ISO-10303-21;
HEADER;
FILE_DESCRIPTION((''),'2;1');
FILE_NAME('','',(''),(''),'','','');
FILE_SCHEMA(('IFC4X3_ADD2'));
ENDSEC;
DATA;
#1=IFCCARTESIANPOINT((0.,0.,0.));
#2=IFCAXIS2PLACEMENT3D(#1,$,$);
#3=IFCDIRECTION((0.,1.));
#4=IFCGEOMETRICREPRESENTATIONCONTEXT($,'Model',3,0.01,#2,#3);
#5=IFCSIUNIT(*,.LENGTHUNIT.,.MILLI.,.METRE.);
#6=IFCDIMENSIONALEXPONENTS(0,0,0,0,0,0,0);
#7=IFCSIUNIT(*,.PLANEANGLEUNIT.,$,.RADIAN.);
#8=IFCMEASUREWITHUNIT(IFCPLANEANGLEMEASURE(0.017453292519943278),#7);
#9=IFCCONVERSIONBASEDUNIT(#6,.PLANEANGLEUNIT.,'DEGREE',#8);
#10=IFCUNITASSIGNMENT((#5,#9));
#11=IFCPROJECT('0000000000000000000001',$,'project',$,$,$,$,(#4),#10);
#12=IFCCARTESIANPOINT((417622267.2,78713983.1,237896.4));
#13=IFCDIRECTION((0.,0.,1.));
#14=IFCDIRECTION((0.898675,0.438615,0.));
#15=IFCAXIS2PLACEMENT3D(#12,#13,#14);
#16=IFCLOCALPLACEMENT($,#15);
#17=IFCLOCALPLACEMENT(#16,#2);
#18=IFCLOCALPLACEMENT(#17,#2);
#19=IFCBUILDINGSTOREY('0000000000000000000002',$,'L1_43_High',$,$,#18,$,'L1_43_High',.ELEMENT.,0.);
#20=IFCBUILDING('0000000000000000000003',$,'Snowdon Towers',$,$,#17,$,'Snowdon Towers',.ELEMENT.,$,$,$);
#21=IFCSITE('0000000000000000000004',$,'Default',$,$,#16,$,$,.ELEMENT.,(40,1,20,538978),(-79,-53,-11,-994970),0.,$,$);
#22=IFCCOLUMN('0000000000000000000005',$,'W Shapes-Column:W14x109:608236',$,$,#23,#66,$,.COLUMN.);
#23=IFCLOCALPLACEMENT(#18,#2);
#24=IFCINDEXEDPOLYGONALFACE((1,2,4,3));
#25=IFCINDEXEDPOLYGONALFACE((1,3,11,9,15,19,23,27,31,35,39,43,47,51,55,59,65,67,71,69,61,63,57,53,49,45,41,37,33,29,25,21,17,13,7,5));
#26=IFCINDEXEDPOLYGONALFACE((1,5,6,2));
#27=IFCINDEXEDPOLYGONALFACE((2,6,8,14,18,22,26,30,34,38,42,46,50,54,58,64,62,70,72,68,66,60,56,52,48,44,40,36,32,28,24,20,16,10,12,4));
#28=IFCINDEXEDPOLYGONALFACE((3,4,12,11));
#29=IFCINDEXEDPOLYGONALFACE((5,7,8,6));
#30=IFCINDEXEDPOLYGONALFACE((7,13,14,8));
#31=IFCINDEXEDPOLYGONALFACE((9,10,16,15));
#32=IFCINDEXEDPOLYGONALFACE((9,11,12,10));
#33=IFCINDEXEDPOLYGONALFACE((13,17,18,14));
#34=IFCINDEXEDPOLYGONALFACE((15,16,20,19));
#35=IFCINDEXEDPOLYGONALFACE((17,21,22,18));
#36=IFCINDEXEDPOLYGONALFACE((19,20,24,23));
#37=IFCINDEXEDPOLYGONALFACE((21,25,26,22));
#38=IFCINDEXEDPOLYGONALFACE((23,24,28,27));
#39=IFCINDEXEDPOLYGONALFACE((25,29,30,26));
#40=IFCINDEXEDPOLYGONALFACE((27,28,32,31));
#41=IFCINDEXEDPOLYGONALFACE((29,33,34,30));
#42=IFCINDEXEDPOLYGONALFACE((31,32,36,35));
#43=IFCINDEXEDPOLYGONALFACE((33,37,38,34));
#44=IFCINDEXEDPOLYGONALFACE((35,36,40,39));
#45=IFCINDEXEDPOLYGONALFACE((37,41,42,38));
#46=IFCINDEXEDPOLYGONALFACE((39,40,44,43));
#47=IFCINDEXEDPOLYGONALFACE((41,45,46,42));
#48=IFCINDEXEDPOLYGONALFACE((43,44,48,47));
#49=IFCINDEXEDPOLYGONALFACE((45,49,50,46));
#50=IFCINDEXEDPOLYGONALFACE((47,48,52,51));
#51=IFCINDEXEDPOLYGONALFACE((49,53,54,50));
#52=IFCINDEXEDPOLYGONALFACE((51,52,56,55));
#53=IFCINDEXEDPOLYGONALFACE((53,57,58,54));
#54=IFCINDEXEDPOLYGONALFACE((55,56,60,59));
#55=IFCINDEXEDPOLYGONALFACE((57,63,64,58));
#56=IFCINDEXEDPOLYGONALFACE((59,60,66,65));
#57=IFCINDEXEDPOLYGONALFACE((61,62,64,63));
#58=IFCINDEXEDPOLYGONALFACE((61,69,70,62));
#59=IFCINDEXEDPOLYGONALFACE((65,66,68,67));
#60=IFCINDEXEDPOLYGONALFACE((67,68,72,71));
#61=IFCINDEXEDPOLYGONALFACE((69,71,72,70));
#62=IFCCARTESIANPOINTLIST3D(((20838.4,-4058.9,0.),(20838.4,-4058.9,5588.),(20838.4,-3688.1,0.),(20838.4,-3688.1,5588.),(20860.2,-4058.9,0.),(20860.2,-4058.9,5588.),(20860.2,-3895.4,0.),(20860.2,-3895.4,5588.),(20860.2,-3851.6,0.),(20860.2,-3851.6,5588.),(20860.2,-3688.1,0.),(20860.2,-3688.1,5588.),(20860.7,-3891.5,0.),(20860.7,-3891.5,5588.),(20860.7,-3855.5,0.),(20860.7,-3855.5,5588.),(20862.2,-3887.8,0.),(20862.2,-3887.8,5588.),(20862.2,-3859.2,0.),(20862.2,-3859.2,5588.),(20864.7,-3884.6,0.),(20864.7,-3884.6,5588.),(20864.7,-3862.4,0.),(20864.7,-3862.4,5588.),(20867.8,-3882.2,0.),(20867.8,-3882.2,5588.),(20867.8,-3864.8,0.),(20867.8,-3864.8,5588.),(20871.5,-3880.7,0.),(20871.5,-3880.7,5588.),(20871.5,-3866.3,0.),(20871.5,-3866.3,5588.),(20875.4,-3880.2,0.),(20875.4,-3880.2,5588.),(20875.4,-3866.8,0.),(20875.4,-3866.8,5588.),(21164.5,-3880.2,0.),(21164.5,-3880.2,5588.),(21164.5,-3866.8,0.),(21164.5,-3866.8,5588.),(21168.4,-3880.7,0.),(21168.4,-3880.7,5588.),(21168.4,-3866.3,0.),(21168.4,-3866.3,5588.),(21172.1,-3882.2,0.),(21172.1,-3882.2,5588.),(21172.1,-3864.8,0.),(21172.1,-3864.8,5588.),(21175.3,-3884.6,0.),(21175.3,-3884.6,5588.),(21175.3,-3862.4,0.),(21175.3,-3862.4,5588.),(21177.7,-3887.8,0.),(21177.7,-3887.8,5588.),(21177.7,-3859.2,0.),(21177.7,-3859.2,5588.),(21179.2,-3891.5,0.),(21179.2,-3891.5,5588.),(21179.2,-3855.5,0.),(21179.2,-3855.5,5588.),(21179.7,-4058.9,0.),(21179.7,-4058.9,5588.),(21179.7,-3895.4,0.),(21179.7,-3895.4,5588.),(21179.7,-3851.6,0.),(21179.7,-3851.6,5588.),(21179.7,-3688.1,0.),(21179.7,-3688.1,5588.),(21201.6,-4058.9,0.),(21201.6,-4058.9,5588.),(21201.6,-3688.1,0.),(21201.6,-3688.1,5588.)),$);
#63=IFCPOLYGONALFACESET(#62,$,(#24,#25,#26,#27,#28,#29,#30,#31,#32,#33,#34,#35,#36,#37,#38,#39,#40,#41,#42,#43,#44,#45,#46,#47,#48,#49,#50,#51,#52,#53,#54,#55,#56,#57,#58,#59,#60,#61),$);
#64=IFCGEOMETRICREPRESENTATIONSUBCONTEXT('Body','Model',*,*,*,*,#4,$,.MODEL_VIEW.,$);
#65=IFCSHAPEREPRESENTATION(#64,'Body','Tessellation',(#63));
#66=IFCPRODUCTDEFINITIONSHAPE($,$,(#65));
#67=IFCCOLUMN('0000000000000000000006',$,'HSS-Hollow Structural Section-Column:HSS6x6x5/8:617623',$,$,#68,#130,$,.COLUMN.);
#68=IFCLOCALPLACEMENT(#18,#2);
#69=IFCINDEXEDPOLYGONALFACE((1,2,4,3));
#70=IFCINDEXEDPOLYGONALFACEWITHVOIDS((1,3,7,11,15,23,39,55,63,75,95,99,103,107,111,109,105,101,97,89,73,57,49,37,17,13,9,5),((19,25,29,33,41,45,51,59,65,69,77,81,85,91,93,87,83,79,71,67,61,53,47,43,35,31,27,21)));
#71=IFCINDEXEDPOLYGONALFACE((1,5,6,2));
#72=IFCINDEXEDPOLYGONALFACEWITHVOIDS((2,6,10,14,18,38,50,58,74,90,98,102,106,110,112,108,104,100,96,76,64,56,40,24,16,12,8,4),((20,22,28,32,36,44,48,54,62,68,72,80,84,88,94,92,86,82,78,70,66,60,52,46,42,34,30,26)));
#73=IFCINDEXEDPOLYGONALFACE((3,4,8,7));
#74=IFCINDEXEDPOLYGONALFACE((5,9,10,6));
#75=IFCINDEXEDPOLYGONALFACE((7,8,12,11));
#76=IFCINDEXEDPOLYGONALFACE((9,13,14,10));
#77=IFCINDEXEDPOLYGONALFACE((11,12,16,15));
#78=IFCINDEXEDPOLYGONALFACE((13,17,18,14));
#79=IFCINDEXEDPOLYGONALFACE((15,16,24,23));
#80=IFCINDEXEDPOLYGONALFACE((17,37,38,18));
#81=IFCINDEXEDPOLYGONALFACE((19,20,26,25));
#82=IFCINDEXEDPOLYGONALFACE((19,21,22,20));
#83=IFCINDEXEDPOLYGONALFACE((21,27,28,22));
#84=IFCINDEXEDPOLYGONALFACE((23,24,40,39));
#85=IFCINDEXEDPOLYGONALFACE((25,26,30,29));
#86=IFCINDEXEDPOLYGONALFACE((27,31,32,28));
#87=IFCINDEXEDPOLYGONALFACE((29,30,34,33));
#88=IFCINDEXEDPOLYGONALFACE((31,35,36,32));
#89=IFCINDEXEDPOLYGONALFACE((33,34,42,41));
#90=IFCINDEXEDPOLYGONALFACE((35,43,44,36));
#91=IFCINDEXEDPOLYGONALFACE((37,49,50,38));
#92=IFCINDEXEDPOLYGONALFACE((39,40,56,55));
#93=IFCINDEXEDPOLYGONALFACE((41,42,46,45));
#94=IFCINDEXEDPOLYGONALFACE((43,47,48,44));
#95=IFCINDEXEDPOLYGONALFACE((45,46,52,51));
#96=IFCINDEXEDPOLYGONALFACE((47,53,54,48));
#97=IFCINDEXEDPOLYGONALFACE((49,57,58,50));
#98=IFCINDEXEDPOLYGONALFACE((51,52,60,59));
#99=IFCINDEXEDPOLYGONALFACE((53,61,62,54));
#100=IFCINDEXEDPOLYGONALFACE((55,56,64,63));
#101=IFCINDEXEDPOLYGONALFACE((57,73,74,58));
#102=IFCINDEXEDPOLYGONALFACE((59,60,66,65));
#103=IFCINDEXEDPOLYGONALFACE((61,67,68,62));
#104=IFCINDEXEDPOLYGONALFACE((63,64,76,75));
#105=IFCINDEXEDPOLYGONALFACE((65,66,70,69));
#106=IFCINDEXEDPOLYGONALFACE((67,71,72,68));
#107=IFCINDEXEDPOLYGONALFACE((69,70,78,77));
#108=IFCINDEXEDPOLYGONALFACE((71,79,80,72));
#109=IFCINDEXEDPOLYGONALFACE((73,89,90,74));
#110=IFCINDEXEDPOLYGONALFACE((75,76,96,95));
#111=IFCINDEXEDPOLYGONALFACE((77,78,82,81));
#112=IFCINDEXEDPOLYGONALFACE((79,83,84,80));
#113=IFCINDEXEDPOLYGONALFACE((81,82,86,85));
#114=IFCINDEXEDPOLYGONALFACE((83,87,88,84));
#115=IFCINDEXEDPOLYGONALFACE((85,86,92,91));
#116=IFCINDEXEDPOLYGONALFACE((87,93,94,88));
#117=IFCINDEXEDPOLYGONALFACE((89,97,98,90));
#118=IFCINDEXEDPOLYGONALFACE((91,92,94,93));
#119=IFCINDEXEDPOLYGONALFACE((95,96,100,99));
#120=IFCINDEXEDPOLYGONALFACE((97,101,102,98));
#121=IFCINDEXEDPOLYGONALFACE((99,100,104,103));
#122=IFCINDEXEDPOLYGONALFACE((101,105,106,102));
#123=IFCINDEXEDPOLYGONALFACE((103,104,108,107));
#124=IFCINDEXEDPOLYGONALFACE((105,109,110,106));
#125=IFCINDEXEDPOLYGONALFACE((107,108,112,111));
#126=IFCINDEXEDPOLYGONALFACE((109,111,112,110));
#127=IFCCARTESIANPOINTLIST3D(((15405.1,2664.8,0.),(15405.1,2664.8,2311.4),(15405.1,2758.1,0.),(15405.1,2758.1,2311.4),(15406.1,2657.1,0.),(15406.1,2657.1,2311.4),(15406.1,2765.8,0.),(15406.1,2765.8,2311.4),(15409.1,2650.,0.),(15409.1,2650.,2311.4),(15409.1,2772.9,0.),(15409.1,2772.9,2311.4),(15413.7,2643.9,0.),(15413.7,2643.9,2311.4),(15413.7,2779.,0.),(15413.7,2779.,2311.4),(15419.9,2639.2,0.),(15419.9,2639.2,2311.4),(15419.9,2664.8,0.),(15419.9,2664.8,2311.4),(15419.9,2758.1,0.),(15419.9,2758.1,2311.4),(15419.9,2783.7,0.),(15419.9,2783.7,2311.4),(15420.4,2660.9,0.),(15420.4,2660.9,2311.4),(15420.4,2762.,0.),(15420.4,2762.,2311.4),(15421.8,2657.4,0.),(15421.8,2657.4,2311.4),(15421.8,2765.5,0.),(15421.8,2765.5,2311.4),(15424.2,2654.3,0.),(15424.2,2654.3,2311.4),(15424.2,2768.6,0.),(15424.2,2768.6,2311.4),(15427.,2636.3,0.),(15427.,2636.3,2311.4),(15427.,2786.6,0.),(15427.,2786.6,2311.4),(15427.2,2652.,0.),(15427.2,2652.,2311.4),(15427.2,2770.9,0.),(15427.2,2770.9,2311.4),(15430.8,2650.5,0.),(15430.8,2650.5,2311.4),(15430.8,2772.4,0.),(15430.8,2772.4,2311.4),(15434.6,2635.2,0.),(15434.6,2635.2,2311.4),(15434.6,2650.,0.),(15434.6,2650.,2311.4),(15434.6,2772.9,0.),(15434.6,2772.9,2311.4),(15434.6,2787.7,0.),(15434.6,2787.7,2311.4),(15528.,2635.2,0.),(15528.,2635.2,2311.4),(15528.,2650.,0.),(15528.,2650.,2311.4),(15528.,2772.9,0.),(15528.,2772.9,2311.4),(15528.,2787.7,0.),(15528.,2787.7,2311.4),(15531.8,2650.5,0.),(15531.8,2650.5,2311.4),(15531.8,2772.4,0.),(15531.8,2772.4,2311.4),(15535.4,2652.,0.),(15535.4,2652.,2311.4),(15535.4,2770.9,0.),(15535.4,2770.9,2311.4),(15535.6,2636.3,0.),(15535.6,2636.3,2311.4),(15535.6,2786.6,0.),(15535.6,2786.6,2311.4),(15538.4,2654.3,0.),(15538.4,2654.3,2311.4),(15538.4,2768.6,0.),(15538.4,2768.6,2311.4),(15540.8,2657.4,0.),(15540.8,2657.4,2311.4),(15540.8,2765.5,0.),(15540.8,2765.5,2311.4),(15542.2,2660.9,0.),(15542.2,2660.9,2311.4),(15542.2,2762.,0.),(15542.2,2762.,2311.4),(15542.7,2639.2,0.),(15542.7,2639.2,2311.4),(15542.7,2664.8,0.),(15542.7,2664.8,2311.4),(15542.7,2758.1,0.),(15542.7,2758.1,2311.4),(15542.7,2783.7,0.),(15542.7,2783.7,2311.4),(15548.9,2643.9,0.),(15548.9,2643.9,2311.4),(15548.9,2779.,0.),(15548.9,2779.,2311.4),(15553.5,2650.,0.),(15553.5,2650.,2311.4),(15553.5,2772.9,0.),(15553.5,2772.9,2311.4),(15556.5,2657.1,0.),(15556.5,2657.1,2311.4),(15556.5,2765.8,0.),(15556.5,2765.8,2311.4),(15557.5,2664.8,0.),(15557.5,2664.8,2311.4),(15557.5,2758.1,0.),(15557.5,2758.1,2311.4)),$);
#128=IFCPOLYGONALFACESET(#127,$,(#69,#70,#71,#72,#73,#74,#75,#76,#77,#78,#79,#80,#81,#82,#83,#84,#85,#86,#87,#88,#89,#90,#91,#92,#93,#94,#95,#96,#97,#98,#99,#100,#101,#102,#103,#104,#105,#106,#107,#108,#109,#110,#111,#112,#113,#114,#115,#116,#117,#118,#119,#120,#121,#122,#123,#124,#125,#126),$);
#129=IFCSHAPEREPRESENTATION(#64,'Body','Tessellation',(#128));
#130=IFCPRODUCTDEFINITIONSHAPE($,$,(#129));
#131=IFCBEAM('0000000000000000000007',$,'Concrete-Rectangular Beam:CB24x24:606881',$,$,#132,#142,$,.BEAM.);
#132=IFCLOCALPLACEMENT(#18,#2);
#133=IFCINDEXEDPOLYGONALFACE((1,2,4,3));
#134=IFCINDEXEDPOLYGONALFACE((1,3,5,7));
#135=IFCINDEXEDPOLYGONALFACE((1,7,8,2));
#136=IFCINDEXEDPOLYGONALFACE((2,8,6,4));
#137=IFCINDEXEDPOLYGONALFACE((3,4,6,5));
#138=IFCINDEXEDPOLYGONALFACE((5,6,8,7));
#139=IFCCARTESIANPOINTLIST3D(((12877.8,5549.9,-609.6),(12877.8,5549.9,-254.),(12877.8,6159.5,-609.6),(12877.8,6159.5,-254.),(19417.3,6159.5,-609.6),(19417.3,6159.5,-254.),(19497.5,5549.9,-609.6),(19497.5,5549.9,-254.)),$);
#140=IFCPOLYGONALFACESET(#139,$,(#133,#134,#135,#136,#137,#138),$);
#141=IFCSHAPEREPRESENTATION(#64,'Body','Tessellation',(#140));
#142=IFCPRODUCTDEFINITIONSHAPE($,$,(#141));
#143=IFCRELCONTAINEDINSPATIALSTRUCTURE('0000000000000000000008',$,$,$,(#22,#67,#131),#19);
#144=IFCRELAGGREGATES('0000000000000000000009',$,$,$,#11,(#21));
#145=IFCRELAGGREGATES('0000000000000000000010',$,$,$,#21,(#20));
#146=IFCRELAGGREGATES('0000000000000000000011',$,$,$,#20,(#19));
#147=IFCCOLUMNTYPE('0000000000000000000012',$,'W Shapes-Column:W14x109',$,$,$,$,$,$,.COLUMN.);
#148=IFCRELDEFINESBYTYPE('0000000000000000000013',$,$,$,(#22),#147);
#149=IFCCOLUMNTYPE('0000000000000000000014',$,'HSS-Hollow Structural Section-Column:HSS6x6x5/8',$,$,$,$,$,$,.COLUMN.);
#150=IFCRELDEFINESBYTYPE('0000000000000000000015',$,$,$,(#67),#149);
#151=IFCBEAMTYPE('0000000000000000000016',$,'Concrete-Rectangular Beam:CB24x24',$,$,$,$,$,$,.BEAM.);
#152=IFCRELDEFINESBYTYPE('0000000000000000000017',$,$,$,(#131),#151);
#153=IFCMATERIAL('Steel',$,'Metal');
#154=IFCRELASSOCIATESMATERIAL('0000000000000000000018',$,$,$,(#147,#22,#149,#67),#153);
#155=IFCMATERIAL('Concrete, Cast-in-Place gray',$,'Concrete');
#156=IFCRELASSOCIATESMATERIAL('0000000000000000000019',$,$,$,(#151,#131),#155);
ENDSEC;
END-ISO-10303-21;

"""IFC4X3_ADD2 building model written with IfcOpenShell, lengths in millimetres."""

from ifc_helpers import new_model, entity, si_unit, converted_unit, direction, frame, frame_2d, origin, place, context, subcontext, project, spatial, polyline, circle_curve, parameter, trimmed, segment, composite_curve, rectangle, i_section, outline, extrude, clip, halfspace, source, transform, mapped, material, material_profile, profile_set, profile_usage, type_object, type_shapes, element, save


model = new_model("IFC4X3_ADD2")

# Units and contexts
model_context = context("Model", 3, precision=0.01, world=origin(), true_north=direction((0.0, 1.0)))
body_context = subcontext(model_context, "Body", "Model", "MODEL_VIEW")
ifc_project = project(units=[si_unit("LENGTHUNIT", "METRE", prefix="MILLI"), converted_unit("PLANEANGLEUNIT", "DEGREE", entity("IfcPlaneAngleMeasure", 0.017453292519943278), si_unit("PLANEANGLEUNIT", "RADIAN"), dimensions=[0, 0, 0, 0, 0, 0, 0])], contexts=[model_context])

# Site, building, storey
site_placement = place(None, frame((417622267.2, 78713983.1, 237896.4), z_axis=(0.0, 0.0, 1.0), x_axis=(0.898675, 0.438615, 0.0)))
site = spatial("IfcSite", under=ifc_project, at=site_placement, Name="Default", CompositionType="ELEMENT", RefLatitude=(40, 1, 20, 538978), RefLongitude=(-79, -53, -11, -994970), RefElevation=0.0)
building_placement = place(site_placement, origin())
building = spatial("IfcBuilding", under=site, at=building_placement, Name="Snowdon Towers", LongName="Snowdon Towers", CompositionType="ELEMENT")
storey_placement = place(building_placement, origin())
storey = spatial("IfcBuildingStorey", under=building, at=storey_placement, Name="L1_43_High", LongName="L1_43_High", CompositionType="ELEMENT", Elevation=0.0)

# Columns
ifc_material_1 = material(Name="Steel", Category="Metal")
ifc_material_profile_1 = material_profile(ifc_material_1, i_section(OverallWidth=370.8, OverallDepth=363.2, WebThickness=13.3, FlangeThickness=21.8, FilletRadius=15.2, at=frame_2d((0.0, 0.0), x_axis=(1.0, 0.0))), Name="W14x109")
ifc_profile_set_1 = profile_set([ifc_material_profile_1], Name="W14x109")
ifc_profile_usage_1 = profile_usage(ifc_profile_set_1)
column_type_1 = type_object("IfcColumnType", Name="W Shapes-Column:W14x109", PredefinedType="COLUMN", material=ifc_profile_set_1)
shared_shape_1 = source(origin(), body_context, "Body", "SweptSolid", [
    extrude(i_section(OverallWidth=370.8, OverallDepth=363.2, WebThickness=13.3, FlangeThickness=21.8, FilletRadius=15.2, at=frame_2d((0.0, 0.0), x_axis=(1.0, 0.0))), frame((0.0, 0.0, 0.0), z_axis=(0.0, 0.0, 1.0), x_axis=(-1.0, 0.0, 0.0)), (0.0, 0.0, 1.0), 5588.0),
])
type_shapes(column_type_1, [shared_shape_1])
for number, where, z_axis, x_axis, name in (
    (1, (21020.0, -3873.5, 0.0), (0.0, 0.0, 1.0), (0.0, 1.0, 0.0), "W Shapes-Column:W14x109:608236"),
):
    element("IfcColumn", number, at=place(storey_placement, frame(where, z_axis=z_axis, x_axis=x_axis)), inside=storey, type_object=column_type_1, material=ifc_profile_usage_1, Name=name, PredefinedType="COLUMN", context=body_context, shape_type="MappedRepresentation", body=[
        mapped(shared_shape_1, transform((0.0, 0.0, 0.0), scale=1.0)),
    ])
ifc_material_profile_2 = material_profile(ifc_material_1, outline(composite_curve([segment(polyline([(-46.7, -76.2), (46.7, -76.2)]), True, "CONTINUOUS"), segment(trimmed(circle_curve(frame_2d((46.7, -46.7), x_axis=(-1.0, 0.0)), 29.5), [parameter(90.0)], [parameter(180.0)], True, "PARAMETER"), True, "CONTINUOUS"), segment(polyline([(76.2, -46.7), (76.2, 46.7)]), True, "CONTINUOUS"), segment(trimmed(circle_curve(frame_2d((46.7, 46.7), x_axis=(-1.0, 0.0)), 29.5), [parameter(180.0)], [parameter(270.0)], True, "PARAMETER"), True, "CONTINUOUS"), segment(polyline([(46.7, 76.2), (-46.7, 76.2)]), True, "CONTINUOUS"), segment(trimmed(circle_curve(frame_2d((-46.7, 46.7), x_axis=(-1.0, 0.0)), 29.5), [parameter(270.0)], [parameter(360.0)], True, "PARAMETER"), True, "CONTINUOUS"), segment(polyline([(-76.2, 46.7), (-76.2, -46.7)]), True, "CONTINUOUS"), segment(trimmed(circle_curve(frame_2d((-46.7, -46.7), x_axis=(-1.0, 0.0)), 29.5), [parameter(360.0)], [parameter(90.0)], True, "PARAMETER"), True, "CONTINUOUS")], self_intersect=False), holes=[composite_curve([segment(trimmed(circle_curve(frame_2d((-46.7, -46.7), x_axis=(-1.0, 0.0)), 14.8), [parameter(0.0)], [parameter(90.0)], True, "PARAMETER"), False, "CONTINUOUS"), segment(polyline([(-61.4, -46.7), (-61.4, 46.7)]), True, "CONTINUOUS"), segment(trimmed(circle_curve(frame_2d((-46.7, 46.7), x_axis=(-1.0, 0.0)), 14.8), [parameter(270.0)], [parameter(0.0)], True, "PARAMETER"), False, "CONTINUOUS"), segment(polyline([(-46.7, 61.4), (46.7, 61.4)]), True, "CONTINUOUS"), segment(trimmed(circle_curve(frame_2d((46.7, 46.7), x_axis=(-1.0, 0.0)), 14.8), [parameter(180.0)], [parameter(270.0)], True, "PARAMETER"), False, "CONTINUOUS"), segment(polyline([(61.4, 46.7), (61.4, -46.7)]), True, "CONTINUOUS"), segment(trimmed(circle_curve(frame_2d((46.7, -46.7), x_axis=(-1.0, 0.0)), 14.8), [parameter(90.0)], [parameter(180.0)], True, "PARAMETER"), False, "CONTINUOUS"), segment(polyline([(46.7, -61.4), (-46.7, -61.4)]), True, "CONTINUOUS")], self_intersect=False)]), Name="HSS6x6x5/8")
ifc_profile_set_2 = profile_set([ifc_material_profile_2], Name="HSS6x6x5/8")
ifc_profile_usage_2 = profile_usage(ifc_profile_set_2)
column_type_2 = type_object("IfcColumnType", Name="HSS-Hollow Structural Section-Column:HSS6x6x5/8", PredefinedType="COLUMN", material=ifc_profile_set_2)
shared_shape_2 = source(origin(), body_context, "Body", "SweptSolid", [
    extrude(outline(composite_curve([segment(polyline([(-46.7, -76.2), (46.7, -76.2)]), True, "CONTINUOUS"), segment(trimmed(circle_curve(frame_2d((46.7, -46.7), x_axis=(-1.0, 0.0)), 29.5), [parameter(90.0)], [parameter(180.0)], True, "PARAMETER"), True, "CONTINUOUS"), segment(polyline([(76.2, -46.7), (76.2, 46.7)]), True, "CONTINUOUS"), segment(trimmed(circle_curve(frame_2d((46.7, 46.7), x_axis=(-1.0, 0.0)), 29.5), [parameter(180.0)], [parameter(270.0)], True, "PARAMETER"), True, "CONTINUOUS"), segment(polyline([(46.7, 76.2), (-46.7, 76.2)]), True, "CONTINUOUS"), segment(trimmed(circle_curve(frame_2d((-46.7, 46.7), x_axis=(-1.0, 0.0)), 29.5), [parameter(270.0)], [parameter(360.0)], True, "PARAMETER"), True, "CONTINUOUS"), segment(polyline([(-76.2, 46.7), (-76.2, -46.7)]), True, "CONTINUOUS"), segment(trimmed(circle_curve(frame_2d((-46.7, -46.7), x_axis=(-1.0, 0.0)), 29.5), [parameter(360.0)], [parameter(90.0)], True, "PARAMETER"), True, "CONTINUOUS")], self_intersect=False), holes=[composite_curve([segment(trimmed(circle_curve(frame_2d((-46.7, -46.7), x_axis=(-1.0, 0.0)), 14.8), [parameter(0.0)], [parameter(90.0)], True, "PARAMETER"), False, "CONTINUOUS"), segment(polyline([(-61.4, -46.7), (-61.4, 46.7)]), True, "CONTINUOUS"), segment(trimmed(circle_curve(frame_2d((-46.7, 46.7), x_axis=(-1.0, 0.0)), 14.8), [parameter(270.0)], [parameter(0.0)], True, "PARAMETER"), False, "CONTINUOUS"), segment(polyline([(-46.7, 61.4), (46.7, 61.4)]), True, "CONTINUOUS"), segment(trimmed(circle_curve(frame_2d((46.7, 46.7), x_axis=(-1.0, 0.0)), 14.8), [parameter(180.0)], [parameter(270.0)], True, "PARAMETER"), False, "CONTINUOUS"), segment(polyline([(61.4, 46.7), (61.4, -46.7)]), True, "CONTINUOUS"), segment(trimmed(circle_curve(frame_2d((46.7, -46.7), x_axis=(-1.0, 0.0)), 14.8), [parameter(90.0)], [parameter(180.0)], True, "PARAMETER"), False, "CONTINUOUS"), segment(polyline([(46.7, -61.4), (-46.7, -61.4)]), True, "CONTINUOUS")], self_intersect=False)]), frame((0.0, 0.0, 0.0), z_axis=(0.0, 0.0, 1.0), x_axis=(-1.0, 0.0, 0.0)), (0.0, 0.0, 1.0), 2311.4),
])
type_shapes(column_type_2, [shared_shape_2])
column_1_placement = place(storey_placement, frame((15481.3, 2711.4, 0.0), z_axis=(0.0, 0.0, 1.0), x_axis=(0.0, 1.0, 0.0)))
element("IfcColumn", 2, at=column_1_placement, inside=storey, type_object=column_type_2, material=ifc_profile_usage_2, Name="HSS-Hollow Structural Section-Column:HSS6x6x5/8:617623", PredefinedType="COLUMN", context=body_context, shape_type="MappedRepresentation", body=[
    mapped(shared_shape_2, transform((0.0, 0.0, 0.0), scale=1.0)),
])

# Beam
ifc_material_2 = material(Name="Concrete, Cast-in-Place gray", Category="Concrete")
ifc_material_profile_3 = material_profile(ifc_material_2, rectangle(XDim=355.6, YDim=609.6, at=frame_2d((0.0, 0.0), x_axis=(1.0, 0.0))), Name="CB24x24")
ifc_profile_set_3 = profile_set([ifc_material_profile_3], Name="CB24x24")
ifc_profile_usage_3 = profile_usage(ifc_profile_set_3, cardinal=8)
beam_type_1 = type_object("IfcBeamType", Name="Concrete-Rectangular Beam:CB24x24", PredefinedType="BEAM", material=ifc_profile_set_3)
shared_shape_3 = source(origin(), body_context, "Body", "Clipping", [
    clip(extrude(rectangle(XDim=355.6, YDim=609.6, at=frame_2d((0.0, 0.0), x_axis=(1.0, 0.0))), frame((12877.8, 5854.7, -431.8), z_axis=(1.0, 0.0, 0.0), x_axis=(0.0, 0.0, -1.0)), (0.0, 0.0, 1.0), 6619.7), halfspace(frame((18529.5, 12902.8, -5334.0), z_axis=(0.991445, 0.130526, 0.0), x_axis=(0.130526, -0.991445, 0.0)), False)),
])
type_shapes(beam_type_1, [shared_shape_3])
beam_1_placement = place(storey_placement, origin())
element("IfcBeam", 3, at=beam_1_placement, inside=storey, type_object=beam_type_1, material=ifc_profile_usage_3, Name="Concrete-Rectangular Beam:CB24x24:606881", PredefinedType="BEAM", context=body_context, shape_type="MappedRepresentation", body=[
    mapped(shared_shape_3, transform((0.0, 0.0, 0.0), scale=1.0)),
])

save(model, "model.ifc")
